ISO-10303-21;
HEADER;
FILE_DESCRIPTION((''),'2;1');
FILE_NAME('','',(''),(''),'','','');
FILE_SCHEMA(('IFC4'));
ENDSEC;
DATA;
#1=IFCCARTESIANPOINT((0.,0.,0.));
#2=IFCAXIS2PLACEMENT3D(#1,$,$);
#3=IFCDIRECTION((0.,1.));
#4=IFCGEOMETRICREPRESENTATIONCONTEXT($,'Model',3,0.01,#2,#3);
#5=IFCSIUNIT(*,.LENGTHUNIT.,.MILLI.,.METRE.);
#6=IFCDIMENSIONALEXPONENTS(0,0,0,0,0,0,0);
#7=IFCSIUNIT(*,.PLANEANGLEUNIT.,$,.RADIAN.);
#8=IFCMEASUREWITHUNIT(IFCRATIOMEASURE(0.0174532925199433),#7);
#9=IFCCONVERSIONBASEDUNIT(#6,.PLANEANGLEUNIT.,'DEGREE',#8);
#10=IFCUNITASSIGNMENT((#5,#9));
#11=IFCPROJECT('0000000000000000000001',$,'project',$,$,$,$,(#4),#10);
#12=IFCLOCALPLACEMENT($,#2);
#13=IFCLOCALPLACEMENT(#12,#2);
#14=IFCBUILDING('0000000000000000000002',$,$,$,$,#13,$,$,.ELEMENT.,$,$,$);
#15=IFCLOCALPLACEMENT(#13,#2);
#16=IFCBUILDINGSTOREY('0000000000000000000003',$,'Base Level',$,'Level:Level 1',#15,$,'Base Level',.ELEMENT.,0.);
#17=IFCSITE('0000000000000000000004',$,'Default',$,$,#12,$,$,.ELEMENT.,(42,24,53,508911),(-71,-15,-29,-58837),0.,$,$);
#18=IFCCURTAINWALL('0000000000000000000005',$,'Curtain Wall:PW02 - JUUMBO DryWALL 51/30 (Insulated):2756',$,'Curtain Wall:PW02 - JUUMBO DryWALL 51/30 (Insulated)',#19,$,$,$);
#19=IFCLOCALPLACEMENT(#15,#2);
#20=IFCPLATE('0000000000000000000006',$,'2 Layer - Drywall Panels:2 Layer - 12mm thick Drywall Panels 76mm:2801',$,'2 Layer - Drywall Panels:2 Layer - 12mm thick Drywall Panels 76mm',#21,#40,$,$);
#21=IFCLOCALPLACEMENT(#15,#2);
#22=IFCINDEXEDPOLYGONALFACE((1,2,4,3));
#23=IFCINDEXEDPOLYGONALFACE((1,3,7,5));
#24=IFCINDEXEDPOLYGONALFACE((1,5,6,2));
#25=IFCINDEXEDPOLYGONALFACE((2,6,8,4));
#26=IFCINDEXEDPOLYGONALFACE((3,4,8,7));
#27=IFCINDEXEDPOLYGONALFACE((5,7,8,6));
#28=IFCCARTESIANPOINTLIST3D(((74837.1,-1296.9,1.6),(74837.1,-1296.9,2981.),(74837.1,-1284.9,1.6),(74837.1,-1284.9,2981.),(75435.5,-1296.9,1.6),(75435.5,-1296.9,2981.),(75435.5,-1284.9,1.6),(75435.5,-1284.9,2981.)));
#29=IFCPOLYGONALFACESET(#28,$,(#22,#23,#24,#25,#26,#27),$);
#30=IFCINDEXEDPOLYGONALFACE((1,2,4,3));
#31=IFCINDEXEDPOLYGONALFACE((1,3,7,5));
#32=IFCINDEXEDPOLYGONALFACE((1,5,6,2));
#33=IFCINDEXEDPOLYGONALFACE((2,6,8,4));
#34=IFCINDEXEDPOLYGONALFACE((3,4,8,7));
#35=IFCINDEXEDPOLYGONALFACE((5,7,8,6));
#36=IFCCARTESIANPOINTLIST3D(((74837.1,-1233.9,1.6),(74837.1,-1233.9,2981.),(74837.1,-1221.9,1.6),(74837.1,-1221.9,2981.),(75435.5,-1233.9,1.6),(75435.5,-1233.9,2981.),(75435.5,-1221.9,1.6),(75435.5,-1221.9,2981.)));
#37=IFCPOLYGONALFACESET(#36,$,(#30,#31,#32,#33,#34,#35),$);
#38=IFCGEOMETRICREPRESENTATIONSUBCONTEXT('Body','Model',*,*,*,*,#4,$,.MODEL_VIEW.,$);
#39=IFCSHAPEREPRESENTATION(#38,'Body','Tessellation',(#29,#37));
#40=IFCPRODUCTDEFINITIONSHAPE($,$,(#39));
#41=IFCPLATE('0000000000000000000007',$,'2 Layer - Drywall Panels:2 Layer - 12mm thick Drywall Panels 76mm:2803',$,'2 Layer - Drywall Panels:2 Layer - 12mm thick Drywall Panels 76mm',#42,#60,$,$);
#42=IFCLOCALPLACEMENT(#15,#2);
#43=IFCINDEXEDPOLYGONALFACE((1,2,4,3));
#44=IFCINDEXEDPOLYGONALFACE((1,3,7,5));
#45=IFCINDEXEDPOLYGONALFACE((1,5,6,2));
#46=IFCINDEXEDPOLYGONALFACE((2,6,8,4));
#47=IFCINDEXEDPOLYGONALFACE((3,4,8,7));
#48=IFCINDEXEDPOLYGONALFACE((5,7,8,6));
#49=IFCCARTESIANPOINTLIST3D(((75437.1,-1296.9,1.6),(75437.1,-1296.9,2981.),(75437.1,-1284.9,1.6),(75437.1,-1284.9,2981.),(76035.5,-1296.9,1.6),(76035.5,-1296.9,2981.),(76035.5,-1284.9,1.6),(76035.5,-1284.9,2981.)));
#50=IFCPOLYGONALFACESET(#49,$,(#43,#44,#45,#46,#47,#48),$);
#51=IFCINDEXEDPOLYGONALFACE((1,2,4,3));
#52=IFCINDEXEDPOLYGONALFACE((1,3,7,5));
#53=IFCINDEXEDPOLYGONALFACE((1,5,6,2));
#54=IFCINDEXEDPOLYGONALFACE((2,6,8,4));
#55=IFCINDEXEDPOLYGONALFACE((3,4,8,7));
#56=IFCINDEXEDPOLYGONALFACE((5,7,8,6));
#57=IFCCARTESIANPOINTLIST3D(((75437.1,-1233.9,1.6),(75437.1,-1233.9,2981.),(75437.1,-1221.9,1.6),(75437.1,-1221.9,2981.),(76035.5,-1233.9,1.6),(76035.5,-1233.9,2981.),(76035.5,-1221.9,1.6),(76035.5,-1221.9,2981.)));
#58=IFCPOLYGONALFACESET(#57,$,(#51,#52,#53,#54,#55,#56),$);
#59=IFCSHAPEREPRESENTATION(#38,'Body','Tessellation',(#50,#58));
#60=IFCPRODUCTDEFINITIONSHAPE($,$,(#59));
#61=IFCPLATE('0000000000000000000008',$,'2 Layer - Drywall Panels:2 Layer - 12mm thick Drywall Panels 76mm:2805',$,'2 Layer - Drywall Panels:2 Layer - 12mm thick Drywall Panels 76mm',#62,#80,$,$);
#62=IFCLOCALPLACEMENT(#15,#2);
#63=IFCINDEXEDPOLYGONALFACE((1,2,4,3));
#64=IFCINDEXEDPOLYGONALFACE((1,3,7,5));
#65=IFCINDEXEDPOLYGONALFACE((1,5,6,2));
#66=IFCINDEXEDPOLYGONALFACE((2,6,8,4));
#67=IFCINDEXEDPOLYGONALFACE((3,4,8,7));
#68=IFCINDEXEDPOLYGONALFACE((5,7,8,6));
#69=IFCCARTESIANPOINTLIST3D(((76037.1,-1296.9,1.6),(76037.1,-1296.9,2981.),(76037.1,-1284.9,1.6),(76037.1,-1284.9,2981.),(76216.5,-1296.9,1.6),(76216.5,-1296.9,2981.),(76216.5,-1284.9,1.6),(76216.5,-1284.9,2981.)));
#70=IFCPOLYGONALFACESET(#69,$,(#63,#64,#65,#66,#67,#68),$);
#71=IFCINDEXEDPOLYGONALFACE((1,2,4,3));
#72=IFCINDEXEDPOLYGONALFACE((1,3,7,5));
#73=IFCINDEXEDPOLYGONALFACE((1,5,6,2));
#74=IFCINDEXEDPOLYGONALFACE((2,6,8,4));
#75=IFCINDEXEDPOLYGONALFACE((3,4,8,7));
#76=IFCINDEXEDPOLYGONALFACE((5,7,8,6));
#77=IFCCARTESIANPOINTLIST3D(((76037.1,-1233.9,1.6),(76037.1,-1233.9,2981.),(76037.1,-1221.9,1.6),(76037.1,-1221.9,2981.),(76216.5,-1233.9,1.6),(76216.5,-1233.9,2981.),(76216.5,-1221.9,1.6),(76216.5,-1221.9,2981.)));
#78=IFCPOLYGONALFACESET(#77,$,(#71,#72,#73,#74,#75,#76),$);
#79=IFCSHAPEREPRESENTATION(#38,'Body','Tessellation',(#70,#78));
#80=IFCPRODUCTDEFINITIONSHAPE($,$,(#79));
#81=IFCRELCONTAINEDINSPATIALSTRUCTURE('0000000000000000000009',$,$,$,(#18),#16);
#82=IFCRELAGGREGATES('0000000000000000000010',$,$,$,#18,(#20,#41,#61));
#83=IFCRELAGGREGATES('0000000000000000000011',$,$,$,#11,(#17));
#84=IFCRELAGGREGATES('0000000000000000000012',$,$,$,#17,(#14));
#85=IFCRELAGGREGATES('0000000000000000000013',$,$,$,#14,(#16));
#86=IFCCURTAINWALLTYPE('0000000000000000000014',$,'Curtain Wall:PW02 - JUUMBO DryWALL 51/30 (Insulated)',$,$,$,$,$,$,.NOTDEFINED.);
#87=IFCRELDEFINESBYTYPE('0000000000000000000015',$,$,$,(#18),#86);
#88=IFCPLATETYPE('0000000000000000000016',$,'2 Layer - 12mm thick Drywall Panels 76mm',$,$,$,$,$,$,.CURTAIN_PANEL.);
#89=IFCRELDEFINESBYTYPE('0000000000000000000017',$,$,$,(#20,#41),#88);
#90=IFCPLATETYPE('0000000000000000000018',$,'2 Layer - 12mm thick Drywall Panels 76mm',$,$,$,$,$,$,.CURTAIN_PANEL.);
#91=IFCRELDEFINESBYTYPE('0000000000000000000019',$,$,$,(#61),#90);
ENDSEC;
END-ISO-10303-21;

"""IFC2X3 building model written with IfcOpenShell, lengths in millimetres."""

from ifc_helpers import new_model, entity, si_unit, converted_unit, direction, frame, frame_2d, origin, origin_2d_with_axis, place, context, subcontext, project, spatial, rectangle, extrude, source, transform, mapped, type_object, type_shapes, element, aggregate, save


model = new_model("IFC2X3")

# Units and contexts
model_context = context("Model", 3, precision=0.01, world=origin(), true_north=direction((0.0, 1.0)))
body_context = subcontext(model_context, "Body", "Model", "MODEL_VIEW")
ifc_project = project(units=[si_unit("LENGTHUNIT", "METRE", prefix="MILLI"), converted_unit("PLANEANGLEUNIT", "DEGREE", entity("IfcRatioMeasure", 0.0174532925199433), si_unit("PLANEANGLEUNIT", "RADIAN"), dimensions=[0, 0, 0, 0, 0, 0, 0])], contexts=[model_context])

# Site, building, storey
site_placement = place(None, origin())
site = spatial("IfcSite", under=ifc_project, at=site_placement, Name="Default", CompositionType="ELEMENT", RefLatitude=(42, 24, 53, 508911), RefLongitude=(-71, -15, -29, -58837), RefElevation=0.0)
building_placement = place(site_placement, origin())
building = spatial("IfcBuilding", under=site, at=building_placement, CompositionType="ELEMENT")
storey_placement = place(building_placement, origin())
storey = spatial("IfcBuildingStorey", under=building, at=storey_placement, Name="Base Level", ObjectType="Level:Level 1", LongName="Base Level", CompositionType="ELEMENT", Elevation=0.0)

# Curtain wall, plates
curtain_wall_type = type_object("IfcCurtainWallType", Name="Curtain Wall:PW02 - JUUMBO DryWALL 51/30 (Insulated)", PredefinedType="NOTDEFINED")
curtain_wall_placement = place(building_placement, origin())
curtain_wall = element("IfcCurtainWall", 1, at=curtain_wall_placement, inside=storey, type_object=curtain_wall_type, Name="Curtain Wall:PW02 - JUUMBO DryWALL 51/30 (Insulated):2756", ObjectType="Curtain Wall:PW02 - JUUMBO DryWALL 51/30 (Insulated)")
plate_type_1 = type_object("IfcPlateType", Name="2 Layer - 12mm thick Drywall Panels 76mm", PredefinedType="CURTAIN_PANEL")
shared_shape_1 = source(origin(), body_context, "Body", "SweptSolid", [
    extrude(rectangle(XDim=598.4, YDim=12.0, at=origin_2d_with_axis()), frame((0.0, -31.5, 0.0), z_axis=(0.0, 0.0, 1.0), x_axis=(-1.0, 0.0, 0.0)), (0.0, 0.0, 1.0), 2979.4),
    extrude(rectangle(XDim=12.0, YDim=598.4, at=frame_2d((0.0, 0.0), x_axis=(1.0, 0.0))), frame((0.0, 31.5, 0.0), z_axis=(0.0, 0.0, 1.0), x_axis=(0.0, 1.0, 0.0)), (0.0, 0.0, 1.0), 2979.4),
])
type_shapes(plate_type_1, [shared_shape_1])
plate_1_placement = place(curtain_wall_placement, frame((75136.3, -1259.4, 1.6)))
plate_1 = element("IfcPlate", 2, at=plate_1_placement, type_object=plate_type_1, Name="2 Layer - Drywall Panels:2 Layer - 12mm thick Drywall Panels 76mm:2801", ObjectType="2 Layer - Drywall Panels:2 Layer - 12mm thick Drywall Panels 76mm", context=body_context, shape_type="MappedRepresentation", body=[
    mapped(shared_shape_1, transform((0.0, 0.0, 0.0), scale=1.0)),
])
plate_2_placement = place(curtain_wall_placement, frame((75736.3, -1259.4, 1.6)))
plate_2 = element("IfcPlate", 3, at=plate_2_placement, type_object=plate_type_1, Name="2 Layer - Drywall Panels:2 Layer - 12mm thick Drywall Panels 76mm:2803", ObjectType="2 Layer - Drywall Panels:2 Layer - 12mm thick Drywall Panels 76mm", context=body_context, shape_type="MappedRepresentation", body=[
    mapped(shared_shape_1, transform((0.0, 0.0, 0.0), scale=1.0)),
])
plate_type_2 = type_object("IfcPlateType", Name="2 Layer - 12mm thick Drywall Panels 76mm", PredefinedType="CURTAIN_PANEL")
shared_shape_2 = source(origin(), body_context, "Body", "SweptSolid", [
    extrude(rectangle(XDim=179.4, YDim=12.0, at=origin_2d_with_axis()), frame((0.0, -31.5, 0.0), z_axis=(0.0, 0.0, 1.0), x_axis=(-1.0, 0.0, 0.0)), (0.0, 0.0, 1.0), 2979.4),
    extrude(rectangle(XDim=12.0, YDim=179.4, at=frame_2d((0.0, 0.0), x_axis=(1.0, 0.0))), frame((0.0, 31.5, 0.0), z_axis=(0.0, 0.0, 1.0), x_axis=(0.0, 1.0, 0.0)), (0.0, 0.0, 1.0), 2979.4),
])
type_shapes(plate_type_2, [shared_shape_2])
plate_3_placement = place(curtain_wall_placement, frame((76126.8, -1259.4, 1.6)))
plate_3 = element("IfcPlate", 4, at=plate_3_placement, type_object=plate_type_2, Name="2 Layer - Drywall Panels:2 Layer - 12mm thick Drywall Panels 76mm:2805", ObjectType="2 Layer - Drywall Panels:2 Layer - 12mm thick Drywall Panels 76mm", context=body_context, shape_type="MappedRepresentation", body=[
    mapped(shared_shape_2, transform((0.0, 0.0, 0.0), scale=1.0)),
])
aggregate(curtain_wall, [plate_1, plate_2, plate_3])

save(model, "model.ifc")
